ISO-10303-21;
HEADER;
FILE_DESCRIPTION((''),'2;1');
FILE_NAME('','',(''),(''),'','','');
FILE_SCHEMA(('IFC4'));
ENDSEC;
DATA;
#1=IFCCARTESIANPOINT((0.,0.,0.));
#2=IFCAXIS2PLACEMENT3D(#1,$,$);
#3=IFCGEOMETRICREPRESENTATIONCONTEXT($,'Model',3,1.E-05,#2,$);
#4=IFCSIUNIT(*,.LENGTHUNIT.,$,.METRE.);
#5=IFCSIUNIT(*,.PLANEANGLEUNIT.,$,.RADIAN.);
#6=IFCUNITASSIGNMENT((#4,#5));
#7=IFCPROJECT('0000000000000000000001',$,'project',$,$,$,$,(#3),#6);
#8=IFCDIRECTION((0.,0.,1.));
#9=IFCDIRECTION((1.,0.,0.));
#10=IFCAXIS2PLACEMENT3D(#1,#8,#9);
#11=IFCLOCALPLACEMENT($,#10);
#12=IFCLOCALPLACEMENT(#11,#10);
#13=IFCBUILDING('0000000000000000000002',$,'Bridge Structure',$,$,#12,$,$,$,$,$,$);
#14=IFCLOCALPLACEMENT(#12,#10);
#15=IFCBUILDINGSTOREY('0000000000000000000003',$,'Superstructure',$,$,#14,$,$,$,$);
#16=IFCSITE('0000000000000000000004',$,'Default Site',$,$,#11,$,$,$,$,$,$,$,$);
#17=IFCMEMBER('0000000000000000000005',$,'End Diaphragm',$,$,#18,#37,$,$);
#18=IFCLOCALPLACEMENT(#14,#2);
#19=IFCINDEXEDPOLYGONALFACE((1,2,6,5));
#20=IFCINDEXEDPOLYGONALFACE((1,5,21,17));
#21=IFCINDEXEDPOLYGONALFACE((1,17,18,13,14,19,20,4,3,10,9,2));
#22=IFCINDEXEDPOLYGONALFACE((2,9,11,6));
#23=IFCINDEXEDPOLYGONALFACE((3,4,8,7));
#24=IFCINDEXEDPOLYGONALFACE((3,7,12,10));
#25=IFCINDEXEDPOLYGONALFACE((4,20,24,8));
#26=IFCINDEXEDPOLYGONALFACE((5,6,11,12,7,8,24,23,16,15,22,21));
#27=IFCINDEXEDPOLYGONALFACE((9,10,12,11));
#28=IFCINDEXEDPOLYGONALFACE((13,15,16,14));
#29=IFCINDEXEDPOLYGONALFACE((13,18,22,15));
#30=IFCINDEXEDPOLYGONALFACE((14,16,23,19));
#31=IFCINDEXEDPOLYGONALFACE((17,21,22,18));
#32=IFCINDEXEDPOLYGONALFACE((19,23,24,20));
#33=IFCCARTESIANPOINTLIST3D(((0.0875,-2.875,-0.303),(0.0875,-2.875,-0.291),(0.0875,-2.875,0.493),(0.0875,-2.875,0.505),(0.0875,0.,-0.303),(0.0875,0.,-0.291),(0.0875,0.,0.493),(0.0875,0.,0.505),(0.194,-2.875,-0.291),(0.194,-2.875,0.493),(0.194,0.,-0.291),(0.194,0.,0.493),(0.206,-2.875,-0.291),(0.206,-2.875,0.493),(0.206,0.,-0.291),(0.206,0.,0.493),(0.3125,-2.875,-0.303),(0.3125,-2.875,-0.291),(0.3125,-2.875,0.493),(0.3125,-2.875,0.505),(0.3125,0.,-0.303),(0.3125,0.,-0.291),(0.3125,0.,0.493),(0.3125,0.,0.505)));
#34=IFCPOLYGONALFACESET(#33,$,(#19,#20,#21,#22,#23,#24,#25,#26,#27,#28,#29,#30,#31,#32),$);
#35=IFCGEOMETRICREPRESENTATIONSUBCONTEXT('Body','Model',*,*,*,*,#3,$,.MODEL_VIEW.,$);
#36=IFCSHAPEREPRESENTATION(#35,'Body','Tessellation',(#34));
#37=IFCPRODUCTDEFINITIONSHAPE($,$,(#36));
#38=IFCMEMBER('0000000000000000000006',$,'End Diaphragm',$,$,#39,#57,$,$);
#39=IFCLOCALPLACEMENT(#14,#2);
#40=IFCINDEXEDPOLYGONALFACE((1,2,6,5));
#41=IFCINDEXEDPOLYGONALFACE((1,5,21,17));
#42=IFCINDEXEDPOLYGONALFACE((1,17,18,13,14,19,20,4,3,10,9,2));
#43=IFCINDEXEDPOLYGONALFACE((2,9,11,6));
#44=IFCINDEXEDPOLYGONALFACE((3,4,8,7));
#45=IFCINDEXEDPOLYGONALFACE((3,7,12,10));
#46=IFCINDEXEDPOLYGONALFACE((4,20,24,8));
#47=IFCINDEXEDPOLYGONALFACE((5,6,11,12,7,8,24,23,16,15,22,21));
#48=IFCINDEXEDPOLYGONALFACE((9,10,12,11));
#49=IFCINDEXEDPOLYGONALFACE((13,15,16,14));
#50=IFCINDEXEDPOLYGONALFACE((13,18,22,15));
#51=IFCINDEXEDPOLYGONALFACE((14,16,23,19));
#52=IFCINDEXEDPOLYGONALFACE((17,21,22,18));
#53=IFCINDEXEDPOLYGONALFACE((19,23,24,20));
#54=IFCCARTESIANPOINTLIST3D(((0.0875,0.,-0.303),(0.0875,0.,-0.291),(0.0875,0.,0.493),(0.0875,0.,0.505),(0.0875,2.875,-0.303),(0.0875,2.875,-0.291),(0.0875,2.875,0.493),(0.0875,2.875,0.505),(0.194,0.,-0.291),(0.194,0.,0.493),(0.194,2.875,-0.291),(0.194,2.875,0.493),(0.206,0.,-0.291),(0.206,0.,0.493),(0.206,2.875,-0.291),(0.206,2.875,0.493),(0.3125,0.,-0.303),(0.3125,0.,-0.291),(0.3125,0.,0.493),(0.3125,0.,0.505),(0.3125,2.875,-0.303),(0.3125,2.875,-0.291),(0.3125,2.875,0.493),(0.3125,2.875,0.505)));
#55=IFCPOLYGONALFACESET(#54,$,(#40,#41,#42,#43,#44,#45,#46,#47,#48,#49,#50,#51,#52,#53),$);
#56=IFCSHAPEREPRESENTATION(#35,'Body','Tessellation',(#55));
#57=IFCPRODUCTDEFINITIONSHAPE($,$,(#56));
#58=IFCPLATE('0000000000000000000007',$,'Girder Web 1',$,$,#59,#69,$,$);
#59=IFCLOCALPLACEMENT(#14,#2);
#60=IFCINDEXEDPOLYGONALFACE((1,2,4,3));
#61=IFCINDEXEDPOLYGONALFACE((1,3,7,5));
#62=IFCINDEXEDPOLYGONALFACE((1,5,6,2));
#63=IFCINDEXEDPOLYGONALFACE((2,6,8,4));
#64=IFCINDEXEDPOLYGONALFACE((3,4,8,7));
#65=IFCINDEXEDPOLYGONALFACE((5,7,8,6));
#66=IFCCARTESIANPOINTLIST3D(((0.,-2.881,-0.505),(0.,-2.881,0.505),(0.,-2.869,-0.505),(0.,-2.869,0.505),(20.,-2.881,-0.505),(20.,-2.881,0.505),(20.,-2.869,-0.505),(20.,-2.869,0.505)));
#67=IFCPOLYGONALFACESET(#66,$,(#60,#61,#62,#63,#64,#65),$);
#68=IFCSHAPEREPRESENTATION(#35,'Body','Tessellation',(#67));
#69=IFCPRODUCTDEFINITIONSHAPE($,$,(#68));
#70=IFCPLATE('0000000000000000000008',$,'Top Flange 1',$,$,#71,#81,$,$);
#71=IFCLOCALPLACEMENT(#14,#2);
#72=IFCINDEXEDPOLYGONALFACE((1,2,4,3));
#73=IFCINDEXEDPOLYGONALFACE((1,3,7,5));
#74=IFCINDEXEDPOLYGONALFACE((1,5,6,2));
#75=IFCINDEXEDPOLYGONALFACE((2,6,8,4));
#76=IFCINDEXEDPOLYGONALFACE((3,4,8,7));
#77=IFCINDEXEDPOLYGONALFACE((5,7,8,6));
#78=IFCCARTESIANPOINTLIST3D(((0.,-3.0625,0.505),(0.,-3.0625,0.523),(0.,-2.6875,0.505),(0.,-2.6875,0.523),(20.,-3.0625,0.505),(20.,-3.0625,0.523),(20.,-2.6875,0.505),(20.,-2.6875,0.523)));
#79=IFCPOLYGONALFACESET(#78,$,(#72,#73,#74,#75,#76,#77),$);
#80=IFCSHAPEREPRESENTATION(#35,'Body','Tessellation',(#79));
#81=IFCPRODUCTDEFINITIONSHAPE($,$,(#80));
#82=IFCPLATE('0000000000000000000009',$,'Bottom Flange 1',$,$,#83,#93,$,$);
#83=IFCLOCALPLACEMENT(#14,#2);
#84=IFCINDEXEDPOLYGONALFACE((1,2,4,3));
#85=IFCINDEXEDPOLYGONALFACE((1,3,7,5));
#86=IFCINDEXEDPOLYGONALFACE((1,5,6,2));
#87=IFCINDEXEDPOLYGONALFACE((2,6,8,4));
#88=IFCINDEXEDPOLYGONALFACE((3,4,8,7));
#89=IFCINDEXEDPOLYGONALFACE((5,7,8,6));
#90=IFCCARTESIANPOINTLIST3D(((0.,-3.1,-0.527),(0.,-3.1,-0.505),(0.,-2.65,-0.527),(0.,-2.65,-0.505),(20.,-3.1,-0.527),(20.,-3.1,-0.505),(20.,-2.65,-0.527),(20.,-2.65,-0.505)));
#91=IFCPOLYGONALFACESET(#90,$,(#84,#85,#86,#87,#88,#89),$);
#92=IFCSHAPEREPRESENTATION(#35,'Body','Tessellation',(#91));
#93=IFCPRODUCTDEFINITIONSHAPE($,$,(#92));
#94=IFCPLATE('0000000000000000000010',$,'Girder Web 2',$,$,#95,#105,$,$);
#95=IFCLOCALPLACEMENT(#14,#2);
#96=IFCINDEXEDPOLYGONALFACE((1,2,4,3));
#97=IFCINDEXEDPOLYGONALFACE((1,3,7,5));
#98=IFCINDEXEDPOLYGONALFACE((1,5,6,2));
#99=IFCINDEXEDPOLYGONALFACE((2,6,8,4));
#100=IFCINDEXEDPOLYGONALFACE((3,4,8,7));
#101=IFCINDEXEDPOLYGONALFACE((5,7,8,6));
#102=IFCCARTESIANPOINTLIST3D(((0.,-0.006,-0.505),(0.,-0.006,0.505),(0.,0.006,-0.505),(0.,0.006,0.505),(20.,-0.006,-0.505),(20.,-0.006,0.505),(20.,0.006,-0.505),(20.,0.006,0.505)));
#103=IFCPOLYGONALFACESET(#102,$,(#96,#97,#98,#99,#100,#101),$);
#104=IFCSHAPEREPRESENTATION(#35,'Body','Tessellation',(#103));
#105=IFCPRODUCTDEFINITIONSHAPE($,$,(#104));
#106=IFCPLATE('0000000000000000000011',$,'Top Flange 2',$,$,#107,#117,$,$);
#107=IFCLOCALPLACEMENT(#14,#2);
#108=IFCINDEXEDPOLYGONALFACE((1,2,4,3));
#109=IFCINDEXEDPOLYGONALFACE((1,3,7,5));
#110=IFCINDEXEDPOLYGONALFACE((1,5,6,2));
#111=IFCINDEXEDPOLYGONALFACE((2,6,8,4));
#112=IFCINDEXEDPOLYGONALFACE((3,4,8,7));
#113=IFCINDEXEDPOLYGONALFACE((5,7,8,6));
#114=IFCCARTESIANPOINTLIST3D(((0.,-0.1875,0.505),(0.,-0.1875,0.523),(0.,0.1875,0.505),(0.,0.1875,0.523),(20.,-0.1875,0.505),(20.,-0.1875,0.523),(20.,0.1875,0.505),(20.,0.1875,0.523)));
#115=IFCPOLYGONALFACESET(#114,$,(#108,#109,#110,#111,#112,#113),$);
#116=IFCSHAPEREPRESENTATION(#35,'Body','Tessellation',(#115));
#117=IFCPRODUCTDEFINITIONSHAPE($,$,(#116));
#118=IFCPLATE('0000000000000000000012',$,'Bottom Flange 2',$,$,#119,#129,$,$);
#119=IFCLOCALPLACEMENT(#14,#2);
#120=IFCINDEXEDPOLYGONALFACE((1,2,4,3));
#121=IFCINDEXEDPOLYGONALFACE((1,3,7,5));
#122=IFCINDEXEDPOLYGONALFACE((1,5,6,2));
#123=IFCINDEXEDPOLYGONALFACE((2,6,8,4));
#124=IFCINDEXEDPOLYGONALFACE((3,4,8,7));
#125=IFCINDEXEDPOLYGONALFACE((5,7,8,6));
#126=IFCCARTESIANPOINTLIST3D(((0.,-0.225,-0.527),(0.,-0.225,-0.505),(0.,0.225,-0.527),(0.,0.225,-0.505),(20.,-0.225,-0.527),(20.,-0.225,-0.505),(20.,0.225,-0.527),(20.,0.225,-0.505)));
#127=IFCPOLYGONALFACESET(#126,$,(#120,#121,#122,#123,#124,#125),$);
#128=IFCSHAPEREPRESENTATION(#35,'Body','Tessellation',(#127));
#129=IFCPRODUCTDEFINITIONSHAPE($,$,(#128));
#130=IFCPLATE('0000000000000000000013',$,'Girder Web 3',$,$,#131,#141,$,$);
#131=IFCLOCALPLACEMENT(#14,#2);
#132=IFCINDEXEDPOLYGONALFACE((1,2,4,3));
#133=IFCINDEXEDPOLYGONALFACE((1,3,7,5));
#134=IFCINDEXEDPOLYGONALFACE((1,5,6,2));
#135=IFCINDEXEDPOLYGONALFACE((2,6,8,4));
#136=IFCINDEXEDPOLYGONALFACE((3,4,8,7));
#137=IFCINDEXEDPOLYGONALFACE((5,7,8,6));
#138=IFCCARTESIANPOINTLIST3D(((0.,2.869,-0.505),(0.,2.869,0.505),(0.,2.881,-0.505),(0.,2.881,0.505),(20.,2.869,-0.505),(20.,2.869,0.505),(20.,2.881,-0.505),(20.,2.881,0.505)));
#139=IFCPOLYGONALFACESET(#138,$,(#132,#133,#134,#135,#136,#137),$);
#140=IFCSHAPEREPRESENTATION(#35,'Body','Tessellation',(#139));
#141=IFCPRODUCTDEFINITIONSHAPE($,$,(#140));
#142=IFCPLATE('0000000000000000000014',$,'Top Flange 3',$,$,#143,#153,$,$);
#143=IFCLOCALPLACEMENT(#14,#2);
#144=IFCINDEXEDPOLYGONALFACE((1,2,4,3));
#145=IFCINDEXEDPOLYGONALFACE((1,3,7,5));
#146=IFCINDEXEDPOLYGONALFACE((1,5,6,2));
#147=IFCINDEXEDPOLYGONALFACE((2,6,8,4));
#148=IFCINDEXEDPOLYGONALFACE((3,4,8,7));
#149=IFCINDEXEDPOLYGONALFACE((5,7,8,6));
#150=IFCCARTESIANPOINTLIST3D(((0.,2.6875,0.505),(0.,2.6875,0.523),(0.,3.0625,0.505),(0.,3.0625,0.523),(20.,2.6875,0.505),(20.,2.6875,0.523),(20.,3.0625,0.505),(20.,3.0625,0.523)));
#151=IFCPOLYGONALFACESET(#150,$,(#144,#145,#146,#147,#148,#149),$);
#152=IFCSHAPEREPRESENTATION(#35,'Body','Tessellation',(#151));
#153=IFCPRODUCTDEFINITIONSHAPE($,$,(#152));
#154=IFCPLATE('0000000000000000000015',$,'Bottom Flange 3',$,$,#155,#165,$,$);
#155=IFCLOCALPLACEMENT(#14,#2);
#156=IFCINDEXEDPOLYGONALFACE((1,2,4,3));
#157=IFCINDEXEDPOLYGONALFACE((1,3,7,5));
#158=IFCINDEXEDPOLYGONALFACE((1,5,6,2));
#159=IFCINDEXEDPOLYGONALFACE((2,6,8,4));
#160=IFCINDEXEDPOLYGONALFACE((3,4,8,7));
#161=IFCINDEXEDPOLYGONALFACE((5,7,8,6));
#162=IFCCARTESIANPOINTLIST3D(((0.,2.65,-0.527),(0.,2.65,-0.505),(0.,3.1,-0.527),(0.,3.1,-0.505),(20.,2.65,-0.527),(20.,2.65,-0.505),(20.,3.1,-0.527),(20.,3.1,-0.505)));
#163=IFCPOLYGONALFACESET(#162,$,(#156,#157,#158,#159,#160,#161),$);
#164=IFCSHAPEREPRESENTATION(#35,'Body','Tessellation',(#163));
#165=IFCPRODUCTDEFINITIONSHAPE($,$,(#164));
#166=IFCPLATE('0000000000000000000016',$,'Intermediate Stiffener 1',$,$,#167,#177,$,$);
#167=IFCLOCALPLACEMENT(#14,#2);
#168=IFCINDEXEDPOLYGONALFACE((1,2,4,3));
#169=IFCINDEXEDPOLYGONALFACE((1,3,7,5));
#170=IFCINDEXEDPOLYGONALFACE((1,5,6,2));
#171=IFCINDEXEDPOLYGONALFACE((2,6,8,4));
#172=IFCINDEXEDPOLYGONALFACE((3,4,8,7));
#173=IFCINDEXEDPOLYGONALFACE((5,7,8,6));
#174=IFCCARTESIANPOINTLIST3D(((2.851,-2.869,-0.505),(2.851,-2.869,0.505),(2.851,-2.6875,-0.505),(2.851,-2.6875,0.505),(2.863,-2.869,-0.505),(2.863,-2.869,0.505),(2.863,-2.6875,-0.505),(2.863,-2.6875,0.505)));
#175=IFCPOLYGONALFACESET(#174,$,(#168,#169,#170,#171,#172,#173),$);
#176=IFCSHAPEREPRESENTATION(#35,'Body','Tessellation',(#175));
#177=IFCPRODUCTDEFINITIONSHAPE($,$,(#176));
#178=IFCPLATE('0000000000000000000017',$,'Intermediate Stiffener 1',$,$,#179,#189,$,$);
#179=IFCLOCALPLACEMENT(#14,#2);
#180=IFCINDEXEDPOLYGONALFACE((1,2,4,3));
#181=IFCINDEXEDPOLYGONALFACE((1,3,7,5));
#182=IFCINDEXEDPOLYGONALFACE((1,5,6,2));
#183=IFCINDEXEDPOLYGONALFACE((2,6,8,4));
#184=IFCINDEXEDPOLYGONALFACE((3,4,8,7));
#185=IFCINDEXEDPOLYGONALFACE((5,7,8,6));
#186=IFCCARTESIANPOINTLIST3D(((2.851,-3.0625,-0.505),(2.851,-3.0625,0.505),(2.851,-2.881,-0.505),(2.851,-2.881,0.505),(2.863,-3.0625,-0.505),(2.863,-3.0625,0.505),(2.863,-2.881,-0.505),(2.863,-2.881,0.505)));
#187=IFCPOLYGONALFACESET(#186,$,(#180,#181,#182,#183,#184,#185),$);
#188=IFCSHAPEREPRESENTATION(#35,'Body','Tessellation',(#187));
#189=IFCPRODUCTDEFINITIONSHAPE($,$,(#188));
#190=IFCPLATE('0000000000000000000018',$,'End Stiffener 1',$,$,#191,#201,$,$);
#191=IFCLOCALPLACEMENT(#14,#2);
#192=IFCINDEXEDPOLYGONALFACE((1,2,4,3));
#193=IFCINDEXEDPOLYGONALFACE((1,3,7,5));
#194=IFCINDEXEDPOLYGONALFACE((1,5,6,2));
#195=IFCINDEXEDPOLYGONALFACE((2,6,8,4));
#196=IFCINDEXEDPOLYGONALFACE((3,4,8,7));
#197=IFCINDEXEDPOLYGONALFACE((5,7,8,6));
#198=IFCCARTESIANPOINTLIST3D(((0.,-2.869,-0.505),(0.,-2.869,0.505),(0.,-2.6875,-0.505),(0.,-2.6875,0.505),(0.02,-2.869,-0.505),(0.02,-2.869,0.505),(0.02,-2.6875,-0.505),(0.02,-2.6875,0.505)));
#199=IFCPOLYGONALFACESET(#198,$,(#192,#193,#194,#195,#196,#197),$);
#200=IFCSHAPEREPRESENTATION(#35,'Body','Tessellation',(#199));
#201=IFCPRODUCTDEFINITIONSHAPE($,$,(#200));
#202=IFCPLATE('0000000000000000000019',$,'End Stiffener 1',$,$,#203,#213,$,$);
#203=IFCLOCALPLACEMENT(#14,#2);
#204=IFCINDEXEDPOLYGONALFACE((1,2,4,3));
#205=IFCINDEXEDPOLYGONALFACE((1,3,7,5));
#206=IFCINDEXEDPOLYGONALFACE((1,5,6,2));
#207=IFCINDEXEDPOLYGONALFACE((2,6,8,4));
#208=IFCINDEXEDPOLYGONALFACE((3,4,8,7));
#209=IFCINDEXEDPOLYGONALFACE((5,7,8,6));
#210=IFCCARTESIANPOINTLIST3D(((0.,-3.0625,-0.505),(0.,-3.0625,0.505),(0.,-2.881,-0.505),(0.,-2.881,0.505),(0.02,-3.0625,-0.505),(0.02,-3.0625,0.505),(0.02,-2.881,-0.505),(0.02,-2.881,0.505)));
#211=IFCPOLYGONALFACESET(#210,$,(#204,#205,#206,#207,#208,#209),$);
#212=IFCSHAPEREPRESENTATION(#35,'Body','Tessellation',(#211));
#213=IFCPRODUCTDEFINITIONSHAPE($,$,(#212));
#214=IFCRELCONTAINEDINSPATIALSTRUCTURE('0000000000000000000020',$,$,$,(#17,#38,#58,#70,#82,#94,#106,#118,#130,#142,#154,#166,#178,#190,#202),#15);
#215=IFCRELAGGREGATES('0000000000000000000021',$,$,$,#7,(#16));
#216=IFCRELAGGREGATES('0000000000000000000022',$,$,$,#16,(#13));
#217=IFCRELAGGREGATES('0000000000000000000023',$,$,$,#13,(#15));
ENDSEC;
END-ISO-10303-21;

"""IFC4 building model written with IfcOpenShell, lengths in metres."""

from ifc_helpers import new_model, si_unit, frame, origin, origin_with_axes, origin_2d_with_axis, place, context, subcontext, project, spatial, rectangle, i_section, extrude, element, save


model = new_model("IFC4")

# Units and contexts
model_context = context("Model", 3, precision=1e-05, world=origin())
body_context = subcontext(model_context, "Body", "Model", "MODEL_VIEW")
ifc_project = project(units=[si_unit("LENGTHUNIT", "METRE"), si_unit("PLANEANGLEUNIT", "RADIAN")], contexts=[model_context])

# Site, building, storey
site_placement = place(None, origin_with_axes())
site = spatial("IfcSite", under=ifc_project, at=site_placement, Name="Default Site")
building_placement = place(site_placement, origin_with_axes())
building = spatial("IfcBuilding", under=site, at=building_placement, Name="Bridge Structure")
storey_placement = place(building_placement, origin_with_axes())
storey = spatial("IfcBuildingStorey", under=building, at=storey_placement, Name="Superstructure")

# Members
for number, where, z_axis, x_axis, name in (
    (1, (0.2, -2.875, 0.101), (0.0, 1.0, 0.0), (-1.0, 0.0, 0.0), "End Diaphragm"),
    (2, (0.2, 0.0, 0.101), (0.0, 1.0, 0.0), (-1.0, 0.0, 0.0), "End Diaphragm"),
):
    element("IfcMember", number, at=place(storey_placement, frame(where, z_axis=z_axis, x_axis=x_axis)), inside=storey, Name=name, context=body_context, shape_type="SweptSolid", body=[
        extrude(i_section(OverallWidth=0.225, OverallDepth=0.808, WebThickness=0.012, FlangeThickness=0.012, at=origin_2d_with_axis()), origin_with_axes(), (0.0, 0.0, 1.0), 2.875),
    ])

# Plates
plate_1_placement = place(storey_placement, frame((0.0, -2.875, 0.0), z_axis=(1.0, 0.0, 0.0), x_axis=(0.0, 1.0, 0.0)))
element("IfcPlate", 3, at=plate_1_placement, inside=storey, Name="Girder Web 1", context=body_context, shape_type="SweptSolid", body=[
    extrude(rectangle(XDim=0.012, YDim=1.01, at=origin_2d_with_axis()), origin_with_axes(), (0.0, 0.0, 1.0), 20.0),
])
plate_2_placement = place(storey_placement, frame((0.0, -2.875, 0.514), z_axis=(1.0, 0.0, 0.0), x_axis=(0.0, 1.0, 0.0)))
element("IfcPlate", 4, at=plate_2_placement, inside=storey, Name="Top Flange 1", context=body_context, shape_type="SweptSolid", body=[
    extrude(rectangle(XDim=0.375, YDim=0.018, at=origin_2d_with_axis()), origin_with_axes(), (0.0, 0.0, 1.0), 20.0),
])
plate_3_placement = place(storey_placement, frame((0.0, -2.875, -0.516), z_axis=(1.0, 0.0, 0.0), x_axis=(0.0, 1.0, 0.0)))
element("IfcPlate", 5, at=plate_3_placement, inside=storey, Name="Bottom Flange 1", context=body_context, shape_type="SweptSolid", body=[
    extrude(rectangle(XDim=0.45, YDim=0.022, at=origin_2d_with_axis()), origin_with_axes(), (0.0, 0.0, 1.0), 20.0),
])
plate_4_placement = place(storey_placement, frame((0.0, 0.0, 0.0), z_axis=(1.0, 0.0, 0.0), x_axis=(0.0, 1.0, 0.0)))
element("IfcPlate", 6, at=plate_4_placement, inside=storey, Name="Girder Web 2", context=body_context, shape_type="SweptSolid", body=[
    extrude(rectangle(XDim=0.012, YDim=1.01, at=origin_2d_with_axis()), origin_with_axes(), (0.0, 0.0, 1.0), 20.0),
])
plate_5_placement = place(storey_placement, frame((0.0, 0.0, 0.514), z_axis=(1.0, 0.0, 0.0), x_axis=(0.0, 1.0, 0.0)))
element("IfcPlate", 7, at=plate_5_placement, inside=storey, Name="Top Flange 2", context=body_context, shape_type="SweptSolid", body=[
    extrude(rectangle(XDim=0.375, YDim=0.018, at=origin_2d_with_axis()), origin_with_axes(), (0.0, 0.0, 1.0), 20.0),
])
plate_6_placement = place(storey_placement, frame((0.0, 0.0, -0.516), z_axis=(1.0, 0.0, 0.0), x_axis=(0.0, 1.0, 0.0)))
element("IfcPlate", 8, at=plate_6_placement, inside=storey, Name="Bottom Flange 2", context=body_context, shape_type="SweptSolid", body=[
    extrude(rectangle(XDim=0.45, YDim=0.022, at=origin_2d_with_axis()), origin_with_axes(), (0.0, 0.0, 1.0), 20.0),
])
plate_7_placement = place(storey_placement, frame((0.0, 2.875, 0.0), z_axis=(1.0, 0.0, 0.0), x_axis=(0.0, 1.0, 0.0)))
element("IfcPlate", 9, at=plate_7_placement, inside=storey, Name="Girder Web 3", context=body_context, shape_type="SweptSolid", body=[
    extrude(rectangle(XDim=0.012, YDim=1.01, at=origin_2d_with_axis()), origin_with_axes(), (0.0, 0.0, 1.0), 20.0),
])
plate_8_placement = place(storey_placement, frame((0.0, 2.875, 0.514), z_axis=(1.0, 0.0, 0.0), x_axis=(0.0, 1.0, 0.0)))
element("IfcPlate", 10, at=plate_8_placement, inside=storey, Name="Top Flange 3", context=body_context, shape_type="SweptSolid", body=[
    extrude(rectangle(XDim=0.375, YDim=0.018, at=origin_2d_with_axis()), origin_with_axes(), (0.0, 0.0, 1.0), 20.0),
])
plate_9_placement = place(storey_placement, frame((0.0, 2.875, -0.516), z_axis=(1.0, 0.0, 0.0), x_axis=(0.0, 1.0, 0.0)))
element("IfcPlate", 11, at=plate_9_placement, inside=storey, Name="Bottom Flange 3", context=body_context, shape_type="SweptSolid", body=[
    extrude(rectangle(XDim=0.45, YDim=0.022, at=origin_2d_with_axis()), origin_with_axes(), (0.0, 0.0, 1.0), 20.0),
])
for number, where, z_axis, x_axis, name in (
    (12, (2.857, -2.7782, -0.505), (0.0, 0.0, 1.0), (1.0, 0.0, 0.0), "Intermediate Stiffener 1"),
    (13, (2.857, -2.9718, -0.505), (0.0, 0.0, 1.0), (1.0, 0.0, 0.0), "Intermediate Stiffener 1"),
):
    element("IfcPlate", number, at=place(storey_placement, frame(where, z_axis=z_axis, x_axis=x_axis)), inside=storey, Name=name, context=body_context, shape_type="SweptSolid", body=[
        extrude(rectangle(XDim=0.012, YDim=0.1815, at=origin_2d_with_axis()), origin_with_axes(), (0.0, 0.0, 1.0), 1.01),
    ])
for number, where, z_axis, x_axis, name in (
    (14, (0.01, -2.7782, -0.505), (0.0, 0.0, 1.0), (1.0, 0.0, 0.0), "End Stiffener 1"),
    (15, (0.01, -2.9718, -0.505), (0.0, 0.0, 1.0), (1.0, 0.0, 0.0), "End Stiffener 1"),
):
    element("IfcPlate", number, at=place(storey_placement, frame(where, z_axis=z_axis, x_axis=x_axis)), inside=storey, Name=name, context=body_context, shape_type="SweptSolid", body=[
        extrude(rectangle(XDim=0.02, YDim=0.1815, at=origin_2d_with_axis()), origin_with_axes(), (0.0, 0.0, 1.0), 1.01),
    ])

save(model, "model.ifc")
